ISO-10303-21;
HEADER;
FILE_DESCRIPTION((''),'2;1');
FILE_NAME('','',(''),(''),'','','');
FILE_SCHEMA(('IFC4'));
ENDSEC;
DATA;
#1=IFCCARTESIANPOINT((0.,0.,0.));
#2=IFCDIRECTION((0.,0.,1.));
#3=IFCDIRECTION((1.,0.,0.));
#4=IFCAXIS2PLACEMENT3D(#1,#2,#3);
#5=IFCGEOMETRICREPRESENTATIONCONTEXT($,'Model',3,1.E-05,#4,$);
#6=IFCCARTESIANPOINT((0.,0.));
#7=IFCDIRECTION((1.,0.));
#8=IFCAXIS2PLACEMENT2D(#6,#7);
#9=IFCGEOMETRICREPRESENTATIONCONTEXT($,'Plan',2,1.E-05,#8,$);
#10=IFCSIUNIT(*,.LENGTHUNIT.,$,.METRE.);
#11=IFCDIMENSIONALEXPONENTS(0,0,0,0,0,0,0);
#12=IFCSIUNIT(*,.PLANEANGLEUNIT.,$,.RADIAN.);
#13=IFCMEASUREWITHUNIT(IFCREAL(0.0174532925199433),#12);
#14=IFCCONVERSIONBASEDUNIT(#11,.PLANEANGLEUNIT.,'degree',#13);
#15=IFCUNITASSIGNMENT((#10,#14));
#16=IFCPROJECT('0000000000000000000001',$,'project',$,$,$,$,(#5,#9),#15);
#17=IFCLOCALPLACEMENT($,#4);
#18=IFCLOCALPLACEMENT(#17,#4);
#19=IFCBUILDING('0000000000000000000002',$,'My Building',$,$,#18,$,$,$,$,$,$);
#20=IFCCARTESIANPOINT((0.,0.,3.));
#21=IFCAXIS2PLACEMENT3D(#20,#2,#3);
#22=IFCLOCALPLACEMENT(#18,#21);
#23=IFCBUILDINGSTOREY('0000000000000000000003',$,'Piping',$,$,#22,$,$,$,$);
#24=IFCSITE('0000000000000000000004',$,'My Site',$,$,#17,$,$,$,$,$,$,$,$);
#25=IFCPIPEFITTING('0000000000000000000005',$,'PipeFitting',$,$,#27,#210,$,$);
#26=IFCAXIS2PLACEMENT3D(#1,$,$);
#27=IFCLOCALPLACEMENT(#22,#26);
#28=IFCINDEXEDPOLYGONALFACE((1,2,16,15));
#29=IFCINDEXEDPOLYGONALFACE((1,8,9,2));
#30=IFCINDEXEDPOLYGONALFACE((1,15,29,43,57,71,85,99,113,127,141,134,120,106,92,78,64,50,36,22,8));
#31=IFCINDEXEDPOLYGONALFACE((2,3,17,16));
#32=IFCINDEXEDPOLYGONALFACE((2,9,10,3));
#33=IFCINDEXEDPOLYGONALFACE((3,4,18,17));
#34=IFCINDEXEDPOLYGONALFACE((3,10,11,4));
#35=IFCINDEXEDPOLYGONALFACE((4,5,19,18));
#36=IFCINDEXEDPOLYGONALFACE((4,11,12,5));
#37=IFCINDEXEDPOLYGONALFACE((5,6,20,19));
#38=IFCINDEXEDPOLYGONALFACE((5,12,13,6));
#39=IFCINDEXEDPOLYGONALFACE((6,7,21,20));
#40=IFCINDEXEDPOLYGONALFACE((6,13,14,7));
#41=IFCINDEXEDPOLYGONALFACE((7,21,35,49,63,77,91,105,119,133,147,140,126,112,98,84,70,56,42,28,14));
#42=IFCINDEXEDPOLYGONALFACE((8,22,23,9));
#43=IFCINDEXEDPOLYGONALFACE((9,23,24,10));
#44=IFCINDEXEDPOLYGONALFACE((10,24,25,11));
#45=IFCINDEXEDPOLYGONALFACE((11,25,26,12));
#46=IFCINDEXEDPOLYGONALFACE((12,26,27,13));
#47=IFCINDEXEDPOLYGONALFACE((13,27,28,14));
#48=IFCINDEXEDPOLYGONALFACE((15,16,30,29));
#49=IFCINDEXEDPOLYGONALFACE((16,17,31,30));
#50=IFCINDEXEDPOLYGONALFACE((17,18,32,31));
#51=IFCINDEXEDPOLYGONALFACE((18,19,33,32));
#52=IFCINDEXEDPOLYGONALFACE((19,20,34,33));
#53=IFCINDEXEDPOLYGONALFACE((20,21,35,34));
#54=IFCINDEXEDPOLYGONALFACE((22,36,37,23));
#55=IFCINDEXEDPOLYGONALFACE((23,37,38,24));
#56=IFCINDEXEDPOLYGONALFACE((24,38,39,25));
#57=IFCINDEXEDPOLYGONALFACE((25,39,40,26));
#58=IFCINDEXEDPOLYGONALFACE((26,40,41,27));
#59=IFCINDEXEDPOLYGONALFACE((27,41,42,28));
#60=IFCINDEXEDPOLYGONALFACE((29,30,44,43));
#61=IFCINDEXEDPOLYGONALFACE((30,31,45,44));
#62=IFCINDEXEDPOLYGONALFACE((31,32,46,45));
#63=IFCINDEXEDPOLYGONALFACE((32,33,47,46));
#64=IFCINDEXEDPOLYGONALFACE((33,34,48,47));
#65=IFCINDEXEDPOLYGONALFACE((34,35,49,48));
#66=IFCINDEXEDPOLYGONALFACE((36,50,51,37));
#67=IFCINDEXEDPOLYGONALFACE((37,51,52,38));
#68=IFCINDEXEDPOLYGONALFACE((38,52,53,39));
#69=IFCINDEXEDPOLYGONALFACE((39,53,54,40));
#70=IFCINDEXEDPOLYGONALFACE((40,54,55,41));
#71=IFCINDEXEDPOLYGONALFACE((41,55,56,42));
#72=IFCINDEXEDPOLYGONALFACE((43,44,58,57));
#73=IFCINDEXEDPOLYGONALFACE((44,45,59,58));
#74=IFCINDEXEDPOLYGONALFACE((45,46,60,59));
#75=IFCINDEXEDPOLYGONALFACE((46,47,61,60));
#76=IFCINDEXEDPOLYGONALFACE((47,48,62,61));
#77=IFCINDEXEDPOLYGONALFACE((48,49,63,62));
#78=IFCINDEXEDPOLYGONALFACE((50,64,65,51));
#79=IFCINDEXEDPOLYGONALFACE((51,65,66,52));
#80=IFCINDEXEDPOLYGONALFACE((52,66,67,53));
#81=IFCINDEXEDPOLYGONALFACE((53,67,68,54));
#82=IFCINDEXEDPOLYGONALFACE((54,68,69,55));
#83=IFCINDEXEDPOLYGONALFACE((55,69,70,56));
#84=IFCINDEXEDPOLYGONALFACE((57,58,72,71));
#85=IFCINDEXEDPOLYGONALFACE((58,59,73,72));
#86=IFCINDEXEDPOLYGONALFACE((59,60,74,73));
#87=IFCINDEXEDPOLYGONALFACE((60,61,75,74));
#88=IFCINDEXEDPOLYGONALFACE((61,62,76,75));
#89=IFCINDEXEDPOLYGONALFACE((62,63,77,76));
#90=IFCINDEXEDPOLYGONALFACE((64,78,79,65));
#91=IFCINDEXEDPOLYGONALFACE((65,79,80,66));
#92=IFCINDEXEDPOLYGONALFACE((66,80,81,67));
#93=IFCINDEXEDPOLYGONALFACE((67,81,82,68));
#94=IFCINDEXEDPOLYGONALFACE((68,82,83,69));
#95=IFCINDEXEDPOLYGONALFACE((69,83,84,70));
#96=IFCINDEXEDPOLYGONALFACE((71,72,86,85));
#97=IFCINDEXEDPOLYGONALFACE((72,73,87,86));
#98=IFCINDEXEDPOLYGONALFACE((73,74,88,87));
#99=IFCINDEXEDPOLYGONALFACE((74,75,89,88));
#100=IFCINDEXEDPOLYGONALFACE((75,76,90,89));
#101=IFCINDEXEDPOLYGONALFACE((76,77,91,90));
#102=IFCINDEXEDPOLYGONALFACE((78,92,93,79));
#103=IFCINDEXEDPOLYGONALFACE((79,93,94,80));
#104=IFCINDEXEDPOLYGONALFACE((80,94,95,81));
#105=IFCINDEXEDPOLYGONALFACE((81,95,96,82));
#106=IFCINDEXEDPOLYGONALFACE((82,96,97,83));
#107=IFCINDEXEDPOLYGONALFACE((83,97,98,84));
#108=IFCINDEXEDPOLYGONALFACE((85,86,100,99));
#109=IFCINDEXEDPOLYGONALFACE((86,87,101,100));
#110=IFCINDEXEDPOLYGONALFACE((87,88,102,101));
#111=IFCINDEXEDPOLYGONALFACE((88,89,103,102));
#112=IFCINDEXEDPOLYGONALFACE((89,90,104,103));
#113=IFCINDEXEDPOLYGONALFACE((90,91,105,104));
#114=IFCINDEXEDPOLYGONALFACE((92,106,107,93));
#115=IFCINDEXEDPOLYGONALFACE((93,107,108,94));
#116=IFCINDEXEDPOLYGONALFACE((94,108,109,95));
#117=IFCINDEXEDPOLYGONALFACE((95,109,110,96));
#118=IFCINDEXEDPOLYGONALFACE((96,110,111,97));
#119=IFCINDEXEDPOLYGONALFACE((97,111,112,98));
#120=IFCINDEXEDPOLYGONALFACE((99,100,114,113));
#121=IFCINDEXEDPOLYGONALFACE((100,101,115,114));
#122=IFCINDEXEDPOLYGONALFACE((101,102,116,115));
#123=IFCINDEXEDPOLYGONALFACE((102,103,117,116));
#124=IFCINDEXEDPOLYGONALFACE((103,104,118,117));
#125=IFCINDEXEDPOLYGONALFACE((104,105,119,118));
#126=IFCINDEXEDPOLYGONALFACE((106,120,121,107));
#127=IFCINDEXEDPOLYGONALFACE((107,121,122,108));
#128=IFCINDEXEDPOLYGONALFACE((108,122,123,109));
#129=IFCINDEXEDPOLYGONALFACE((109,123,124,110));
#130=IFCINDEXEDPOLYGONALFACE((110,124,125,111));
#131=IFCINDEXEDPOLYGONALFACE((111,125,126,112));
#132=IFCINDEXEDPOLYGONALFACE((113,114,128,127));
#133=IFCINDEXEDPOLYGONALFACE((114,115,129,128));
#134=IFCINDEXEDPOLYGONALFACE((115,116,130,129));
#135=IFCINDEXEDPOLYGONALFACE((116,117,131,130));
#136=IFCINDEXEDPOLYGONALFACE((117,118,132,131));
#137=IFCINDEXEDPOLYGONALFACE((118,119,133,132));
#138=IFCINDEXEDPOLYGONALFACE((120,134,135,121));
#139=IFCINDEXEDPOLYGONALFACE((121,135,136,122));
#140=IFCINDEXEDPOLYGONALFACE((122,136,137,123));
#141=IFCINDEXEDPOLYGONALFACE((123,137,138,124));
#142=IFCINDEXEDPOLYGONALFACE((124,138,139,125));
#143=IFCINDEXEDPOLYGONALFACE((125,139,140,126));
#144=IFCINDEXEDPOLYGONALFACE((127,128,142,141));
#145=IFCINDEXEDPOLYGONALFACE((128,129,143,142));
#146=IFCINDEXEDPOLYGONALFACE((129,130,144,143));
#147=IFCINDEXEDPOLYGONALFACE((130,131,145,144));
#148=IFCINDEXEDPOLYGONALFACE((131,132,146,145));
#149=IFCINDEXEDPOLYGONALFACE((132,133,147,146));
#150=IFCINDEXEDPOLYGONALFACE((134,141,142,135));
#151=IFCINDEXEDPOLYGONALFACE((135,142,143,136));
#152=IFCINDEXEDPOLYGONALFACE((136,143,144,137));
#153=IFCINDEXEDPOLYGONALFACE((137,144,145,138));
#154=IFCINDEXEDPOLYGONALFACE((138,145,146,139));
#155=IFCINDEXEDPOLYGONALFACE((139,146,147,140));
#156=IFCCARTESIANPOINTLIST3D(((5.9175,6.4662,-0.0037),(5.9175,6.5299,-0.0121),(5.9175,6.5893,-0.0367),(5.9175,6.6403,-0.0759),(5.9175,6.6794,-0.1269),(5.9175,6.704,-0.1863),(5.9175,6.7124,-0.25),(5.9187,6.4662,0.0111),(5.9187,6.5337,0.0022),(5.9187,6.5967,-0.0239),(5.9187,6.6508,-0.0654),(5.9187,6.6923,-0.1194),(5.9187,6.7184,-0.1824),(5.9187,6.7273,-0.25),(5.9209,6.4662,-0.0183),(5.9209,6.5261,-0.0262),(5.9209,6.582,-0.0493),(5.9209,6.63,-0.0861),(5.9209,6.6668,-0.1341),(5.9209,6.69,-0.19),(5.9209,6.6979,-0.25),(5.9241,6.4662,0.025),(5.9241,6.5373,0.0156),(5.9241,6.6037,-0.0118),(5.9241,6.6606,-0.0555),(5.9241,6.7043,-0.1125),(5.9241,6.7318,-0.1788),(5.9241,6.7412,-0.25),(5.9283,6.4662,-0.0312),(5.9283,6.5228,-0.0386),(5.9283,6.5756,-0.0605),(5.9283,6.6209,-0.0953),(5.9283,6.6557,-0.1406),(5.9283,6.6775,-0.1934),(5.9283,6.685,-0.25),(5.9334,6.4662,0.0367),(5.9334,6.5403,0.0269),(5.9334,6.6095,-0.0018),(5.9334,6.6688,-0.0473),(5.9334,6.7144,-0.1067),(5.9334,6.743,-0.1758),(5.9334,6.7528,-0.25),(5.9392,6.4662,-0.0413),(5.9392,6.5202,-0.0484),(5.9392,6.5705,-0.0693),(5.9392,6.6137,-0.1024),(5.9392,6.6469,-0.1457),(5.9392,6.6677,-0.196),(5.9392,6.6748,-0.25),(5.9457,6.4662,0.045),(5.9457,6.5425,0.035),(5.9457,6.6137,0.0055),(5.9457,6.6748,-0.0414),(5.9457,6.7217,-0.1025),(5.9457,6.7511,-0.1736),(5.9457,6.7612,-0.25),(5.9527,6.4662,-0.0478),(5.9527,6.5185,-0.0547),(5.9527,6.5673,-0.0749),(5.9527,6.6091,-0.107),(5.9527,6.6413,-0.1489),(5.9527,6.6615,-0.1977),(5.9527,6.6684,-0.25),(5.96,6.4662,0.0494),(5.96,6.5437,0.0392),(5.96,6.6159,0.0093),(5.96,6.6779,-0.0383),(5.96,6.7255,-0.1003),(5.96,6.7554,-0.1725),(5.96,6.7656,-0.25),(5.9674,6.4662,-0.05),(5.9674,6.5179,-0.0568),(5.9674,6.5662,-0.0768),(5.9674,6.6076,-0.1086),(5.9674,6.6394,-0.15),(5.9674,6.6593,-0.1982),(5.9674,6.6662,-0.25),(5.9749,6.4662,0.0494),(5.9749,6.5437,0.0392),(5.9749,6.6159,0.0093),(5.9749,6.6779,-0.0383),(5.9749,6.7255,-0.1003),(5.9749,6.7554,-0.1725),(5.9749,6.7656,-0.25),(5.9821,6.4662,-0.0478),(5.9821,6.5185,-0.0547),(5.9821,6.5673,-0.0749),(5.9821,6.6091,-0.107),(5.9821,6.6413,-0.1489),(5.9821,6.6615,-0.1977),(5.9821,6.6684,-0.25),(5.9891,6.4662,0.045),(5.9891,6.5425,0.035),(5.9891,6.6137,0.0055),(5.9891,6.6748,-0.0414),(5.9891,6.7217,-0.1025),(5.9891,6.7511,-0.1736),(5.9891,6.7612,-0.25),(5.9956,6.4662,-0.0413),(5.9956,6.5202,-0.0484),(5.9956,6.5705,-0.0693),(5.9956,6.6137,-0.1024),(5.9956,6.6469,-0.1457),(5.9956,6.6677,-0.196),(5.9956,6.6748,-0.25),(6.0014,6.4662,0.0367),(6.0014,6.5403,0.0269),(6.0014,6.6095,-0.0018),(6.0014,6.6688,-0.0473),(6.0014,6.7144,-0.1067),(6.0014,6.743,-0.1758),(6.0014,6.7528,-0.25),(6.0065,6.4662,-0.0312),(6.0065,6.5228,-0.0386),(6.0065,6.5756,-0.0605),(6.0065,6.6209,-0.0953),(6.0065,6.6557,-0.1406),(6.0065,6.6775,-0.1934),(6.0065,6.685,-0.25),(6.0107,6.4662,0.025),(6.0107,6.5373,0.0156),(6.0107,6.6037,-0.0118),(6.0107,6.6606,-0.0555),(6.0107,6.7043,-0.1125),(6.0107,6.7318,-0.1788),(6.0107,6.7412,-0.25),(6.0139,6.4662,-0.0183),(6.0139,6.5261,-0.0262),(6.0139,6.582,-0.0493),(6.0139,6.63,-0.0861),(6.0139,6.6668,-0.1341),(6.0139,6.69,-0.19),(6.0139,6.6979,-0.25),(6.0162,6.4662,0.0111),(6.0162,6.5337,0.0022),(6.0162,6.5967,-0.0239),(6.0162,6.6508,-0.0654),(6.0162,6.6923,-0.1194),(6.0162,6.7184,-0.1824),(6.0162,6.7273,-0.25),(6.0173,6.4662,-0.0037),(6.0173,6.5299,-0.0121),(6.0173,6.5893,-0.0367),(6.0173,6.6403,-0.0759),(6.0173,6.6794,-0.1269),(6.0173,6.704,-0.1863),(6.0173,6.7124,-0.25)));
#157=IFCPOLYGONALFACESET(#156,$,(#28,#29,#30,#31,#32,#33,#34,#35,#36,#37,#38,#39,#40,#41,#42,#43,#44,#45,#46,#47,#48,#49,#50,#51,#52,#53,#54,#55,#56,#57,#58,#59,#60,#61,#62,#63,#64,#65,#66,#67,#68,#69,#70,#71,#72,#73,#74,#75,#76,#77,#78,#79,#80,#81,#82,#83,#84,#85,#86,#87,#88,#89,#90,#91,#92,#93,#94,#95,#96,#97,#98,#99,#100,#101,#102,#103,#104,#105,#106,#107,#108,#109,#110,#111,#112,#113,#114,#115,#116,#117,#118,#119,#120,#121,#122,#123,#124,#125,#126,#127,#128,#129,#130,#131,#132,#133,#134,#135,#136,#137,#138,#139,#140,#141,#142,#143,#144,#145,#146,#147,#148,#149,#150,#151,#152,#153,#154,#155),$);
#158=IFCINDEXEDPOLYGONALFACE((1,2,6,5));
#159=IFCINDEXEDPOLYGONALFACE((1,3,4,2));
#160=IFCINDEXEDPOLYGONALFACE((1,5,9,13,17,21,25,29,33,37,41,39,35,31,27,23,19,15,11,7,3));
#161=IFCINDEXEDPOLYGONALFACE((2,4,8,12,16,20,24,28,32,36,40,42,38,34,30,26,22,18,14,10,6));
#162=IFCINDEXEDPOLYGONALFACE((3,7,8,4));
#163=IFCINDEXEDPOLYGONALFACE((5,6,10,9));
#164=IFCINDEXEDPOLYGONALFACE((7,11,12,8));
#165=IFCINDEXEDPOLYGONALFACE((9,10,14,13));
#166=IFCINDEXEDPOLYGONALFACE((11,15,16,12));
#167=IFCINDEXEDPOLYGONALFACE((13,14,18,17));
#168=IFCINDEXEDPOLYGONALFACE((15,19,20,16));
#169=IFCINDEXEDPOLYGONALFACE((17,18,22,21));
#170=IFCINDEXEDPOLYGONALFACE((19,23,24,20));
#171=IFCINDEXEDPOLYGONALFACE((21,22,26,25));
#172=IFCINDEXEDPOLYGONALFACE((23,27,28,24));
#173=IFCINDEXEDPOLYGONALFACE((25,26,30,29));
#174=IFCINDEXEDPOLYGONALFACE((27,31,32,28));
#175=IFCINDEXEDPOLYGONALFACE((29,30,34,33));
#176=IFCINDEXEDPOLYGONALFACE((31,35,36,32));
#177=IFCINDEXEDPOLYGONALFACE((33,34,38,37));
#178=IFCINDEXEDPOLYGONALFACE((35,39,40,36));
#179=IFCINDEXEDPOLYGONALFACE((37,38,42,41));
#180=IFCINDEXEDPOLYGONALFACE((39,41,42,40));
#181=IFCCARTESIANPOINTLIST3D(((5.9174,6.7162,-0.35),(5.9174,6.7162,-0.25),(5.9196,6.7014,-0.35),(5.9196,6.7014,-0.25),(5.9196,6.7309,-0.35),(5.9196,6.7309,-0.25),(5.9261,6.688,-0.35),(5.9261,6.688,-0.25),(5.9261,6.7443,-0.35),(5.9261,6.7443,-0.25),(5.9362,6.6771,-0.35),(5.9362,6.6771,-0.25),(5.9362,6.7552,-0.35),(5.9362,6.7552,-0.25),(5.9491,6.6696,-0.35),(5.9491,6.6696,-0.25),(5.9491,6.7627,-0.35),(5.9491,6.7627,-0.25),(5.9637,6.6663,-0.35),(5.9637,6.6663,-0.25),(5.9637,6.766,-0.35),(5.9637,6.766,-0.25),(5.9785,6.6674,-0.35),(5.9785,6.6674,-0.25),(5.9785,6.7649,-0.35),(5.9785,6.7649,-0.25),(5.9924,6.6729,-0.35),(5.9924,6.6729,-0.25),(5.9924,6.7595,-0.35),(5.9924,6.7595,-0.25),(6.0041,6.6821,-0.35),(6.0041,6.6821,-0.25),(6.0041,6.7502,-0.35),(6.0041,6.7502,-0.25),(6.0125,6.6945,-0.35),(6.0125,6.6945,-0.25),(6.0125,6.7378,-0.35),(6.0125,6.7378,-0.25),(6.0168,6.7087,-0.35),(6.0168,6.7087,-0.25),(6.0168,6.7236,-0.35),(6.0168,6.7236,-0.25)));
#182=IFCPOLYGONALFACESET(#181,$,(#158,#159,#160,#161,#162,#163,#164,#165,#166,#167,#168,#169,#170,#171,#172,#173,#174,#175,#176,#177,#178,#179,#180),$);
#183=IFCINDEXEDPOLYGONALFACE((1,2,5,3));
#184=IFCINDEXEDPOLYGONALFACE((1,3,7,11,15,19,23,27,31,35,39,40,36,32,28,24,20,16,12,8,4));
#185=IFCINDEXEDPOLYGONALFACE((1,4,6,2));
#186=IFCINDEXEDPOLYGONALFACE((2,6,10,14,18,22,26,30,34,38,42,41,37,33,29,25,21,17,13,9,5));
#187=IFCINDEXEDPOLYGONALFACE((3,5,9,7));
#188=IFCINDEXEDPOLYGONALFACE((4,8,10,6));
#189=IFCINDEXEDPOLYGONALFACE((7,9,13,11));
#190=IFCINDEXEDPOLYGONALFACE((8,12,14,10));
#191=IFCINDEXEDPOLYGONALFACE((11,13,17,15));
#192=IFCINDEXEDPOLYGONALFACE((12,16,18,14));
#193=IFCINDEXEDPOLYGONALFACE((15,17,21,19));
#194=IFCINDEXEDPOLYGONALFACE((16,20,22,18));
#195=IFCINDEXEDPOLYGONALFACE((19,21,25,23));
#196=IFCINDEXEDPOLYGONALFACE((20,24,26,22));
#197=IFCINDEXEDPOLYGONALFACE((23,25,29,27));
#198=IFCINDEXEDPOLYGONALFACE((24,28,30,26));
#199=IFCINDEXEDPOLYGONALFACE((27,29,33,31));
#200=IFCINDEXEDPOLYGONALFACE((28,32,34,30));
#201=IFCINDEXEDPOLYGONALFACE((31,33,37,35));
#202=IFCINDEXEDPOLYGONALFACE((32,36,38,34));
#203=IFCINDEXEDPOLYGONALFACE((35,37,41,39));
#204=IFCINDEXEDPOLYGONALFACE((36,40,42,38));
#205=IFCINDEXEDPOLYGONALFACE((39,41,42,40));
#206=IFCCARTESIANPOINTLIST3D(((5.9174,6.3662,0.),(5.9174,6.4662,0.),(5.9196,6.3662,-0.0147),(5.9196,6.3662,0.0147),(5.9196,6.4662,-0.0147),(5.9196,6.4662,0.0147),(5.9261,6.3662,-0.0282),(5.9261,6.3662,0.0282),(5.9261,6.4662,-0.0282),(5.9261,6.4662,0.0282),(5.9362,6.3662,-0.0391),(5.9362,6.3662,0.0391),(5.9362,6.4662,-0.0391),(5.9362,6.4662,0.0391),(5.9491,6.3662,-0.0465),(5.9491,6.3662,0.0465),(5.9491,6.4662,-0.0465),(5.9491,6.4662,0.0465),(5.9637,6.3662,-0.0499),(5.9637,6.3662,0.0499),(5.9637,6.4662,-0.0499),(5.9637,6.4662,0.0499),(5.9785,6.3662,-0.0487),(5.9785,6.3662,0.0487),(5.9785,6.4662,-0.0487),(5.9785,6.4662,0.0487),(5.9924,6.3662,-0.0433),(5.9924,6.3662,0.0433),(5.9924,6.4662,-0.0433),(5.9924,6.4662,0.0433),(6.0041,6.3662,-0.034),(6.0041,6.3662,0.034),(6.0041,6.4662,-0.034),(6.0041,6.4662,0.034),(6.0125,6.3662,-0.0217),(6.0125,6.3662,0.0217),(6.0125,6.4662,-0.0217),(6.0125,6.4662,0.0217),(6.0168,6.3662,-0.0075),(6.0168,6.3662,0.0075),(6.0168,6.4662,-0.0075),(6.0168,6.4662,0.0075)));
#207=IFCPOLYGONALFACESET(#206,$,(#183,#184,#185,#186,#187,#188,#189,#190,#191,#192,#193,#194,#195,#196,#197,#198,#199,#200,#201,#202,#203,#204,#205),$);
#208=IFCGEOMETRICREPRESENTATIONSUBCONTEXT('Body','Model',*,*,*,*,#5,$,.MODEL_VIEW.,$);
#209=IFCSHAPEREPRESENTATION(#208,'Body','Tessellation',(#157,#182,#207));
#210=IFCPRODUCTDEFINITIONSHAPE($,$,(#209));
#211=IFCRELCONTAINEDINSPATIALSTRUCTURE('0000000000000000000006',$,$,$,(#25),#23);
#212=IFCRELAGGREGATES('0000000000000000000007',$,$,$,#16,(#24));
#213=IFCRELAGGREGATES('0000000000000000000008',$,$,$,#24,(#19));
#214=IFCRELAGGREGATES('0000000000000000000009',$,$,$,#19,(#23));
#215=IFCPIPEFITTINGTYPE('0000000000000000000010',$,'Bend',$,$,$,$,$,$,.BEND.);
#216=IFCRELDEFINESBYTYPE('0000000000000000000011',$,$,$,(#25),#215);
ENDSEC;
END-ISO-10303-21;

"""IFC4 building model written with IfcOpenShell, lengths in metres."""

from ifc_helpers import new_model, entity, si_unit, converted_unit, frame, origin_with_axes, origin_2d_with_axis, place, context, subcontext, project, spatial, circle, extrude, source, transform, mapped, type_object, type_shapes, element, save


model = new_model("IFC4")

# Units and contexts
model_context = context("Model", 3, precision=1e-05, world=origin_with_axes())
plan_context = context("Plan", 2, precision=1e-05, world=origin_2d_with_axis())
body_context = subcontext(model_context, "Body", "Model", "MODEL_VIEW")
ifc_project = project(units=[si_unit("LENGTHUNIT", "METRE"), converted_unit("PLANEANGLEUNIT", "degree", entity("IfcReal", 0.0174532925199433), si_unit("PLANEANGLEUNIT", "RADIAN"), dimensions=[0, 0, 0, 0, 0, 0, 0])], contexts=[model_context, plan_context])

# Site, building, storey
site_placement = place(None, origin_with_axes())
site = spatial("IfcSite", under=ifc_project, at=site_placement, Name="My Site")
building_placement = place(site_placement, origin_with_axes())
building = spatial("IfcBuilding", under=site, at=building_placement, Name="My Building")
storey_placement = place(building_placement, frame((0.0, 0.0, 3.0), z_axis=(0.0, 0.0, 1.0), x_axis=(1.0, 0.0, 0.0)))
storey = spatial("IfcBuildingStorey", under=building, at=storey_placement, Name="Piping")

# Pipe fitting
pipe_fitting_type = type_object("IfcPipeFittingType", Name="Bend", PredefinedType="BEND")
shared_shape = source(origin_with_axes(), body_context, "Body", "SolidModel", [
    entity("IfcSweptDiskSolid", entity("IfcIndexedPolyCurve", entity("IfcCartesianPointList3D", [[0.0, 0.0, -0.1], [0.0, -0.0732, -0.2768], [0.0, -0.25, -0.35]]), [entity("IfcArcIndex", [1, 2, 3])]), 0.05),
    extrude(circle(Radius=0.05), origin_with_axes(), (0.0, 0.0, -1.0), 0.1),
    extrude(circle(Radius=0.05), frame((0.0, -0.25, -0.35), z_axis=(0.0, -1.0, 0.0), x_axis=(1.0, 0.0, 0.0)), (0.0, 0.0, 1.0), 0.1),
])
type_shapes(pipe_fitting_type, [shared_shape])
for number, where, z_axis, x_axis, name in (
    (1, (5.9674, 6.7162, -0.35), (0.0, 0.0, -1.0), (-1.0, 0.0, 0.0), "PipeFitting"),
):
    element("IfcPipeFitting", number, at=place(storey_placement, frame(where, z_axis=z_axis, x_axis=x_axis)), inside=storey, type_object=pipe_fitting_type, Name=name, context=body_context, shape_type="MappedRepresentation", body=[
        mapped(shared_shape, transform((0.0, 0.0, 0.0), x_axis=(1.0, 0.0, 0.0), y_axis=(0.0, 1.0, 0.0), z_axis=(0.0, 0.0, 1.0), scale=1.0)),
    ])

save(model, "model.ifc")
